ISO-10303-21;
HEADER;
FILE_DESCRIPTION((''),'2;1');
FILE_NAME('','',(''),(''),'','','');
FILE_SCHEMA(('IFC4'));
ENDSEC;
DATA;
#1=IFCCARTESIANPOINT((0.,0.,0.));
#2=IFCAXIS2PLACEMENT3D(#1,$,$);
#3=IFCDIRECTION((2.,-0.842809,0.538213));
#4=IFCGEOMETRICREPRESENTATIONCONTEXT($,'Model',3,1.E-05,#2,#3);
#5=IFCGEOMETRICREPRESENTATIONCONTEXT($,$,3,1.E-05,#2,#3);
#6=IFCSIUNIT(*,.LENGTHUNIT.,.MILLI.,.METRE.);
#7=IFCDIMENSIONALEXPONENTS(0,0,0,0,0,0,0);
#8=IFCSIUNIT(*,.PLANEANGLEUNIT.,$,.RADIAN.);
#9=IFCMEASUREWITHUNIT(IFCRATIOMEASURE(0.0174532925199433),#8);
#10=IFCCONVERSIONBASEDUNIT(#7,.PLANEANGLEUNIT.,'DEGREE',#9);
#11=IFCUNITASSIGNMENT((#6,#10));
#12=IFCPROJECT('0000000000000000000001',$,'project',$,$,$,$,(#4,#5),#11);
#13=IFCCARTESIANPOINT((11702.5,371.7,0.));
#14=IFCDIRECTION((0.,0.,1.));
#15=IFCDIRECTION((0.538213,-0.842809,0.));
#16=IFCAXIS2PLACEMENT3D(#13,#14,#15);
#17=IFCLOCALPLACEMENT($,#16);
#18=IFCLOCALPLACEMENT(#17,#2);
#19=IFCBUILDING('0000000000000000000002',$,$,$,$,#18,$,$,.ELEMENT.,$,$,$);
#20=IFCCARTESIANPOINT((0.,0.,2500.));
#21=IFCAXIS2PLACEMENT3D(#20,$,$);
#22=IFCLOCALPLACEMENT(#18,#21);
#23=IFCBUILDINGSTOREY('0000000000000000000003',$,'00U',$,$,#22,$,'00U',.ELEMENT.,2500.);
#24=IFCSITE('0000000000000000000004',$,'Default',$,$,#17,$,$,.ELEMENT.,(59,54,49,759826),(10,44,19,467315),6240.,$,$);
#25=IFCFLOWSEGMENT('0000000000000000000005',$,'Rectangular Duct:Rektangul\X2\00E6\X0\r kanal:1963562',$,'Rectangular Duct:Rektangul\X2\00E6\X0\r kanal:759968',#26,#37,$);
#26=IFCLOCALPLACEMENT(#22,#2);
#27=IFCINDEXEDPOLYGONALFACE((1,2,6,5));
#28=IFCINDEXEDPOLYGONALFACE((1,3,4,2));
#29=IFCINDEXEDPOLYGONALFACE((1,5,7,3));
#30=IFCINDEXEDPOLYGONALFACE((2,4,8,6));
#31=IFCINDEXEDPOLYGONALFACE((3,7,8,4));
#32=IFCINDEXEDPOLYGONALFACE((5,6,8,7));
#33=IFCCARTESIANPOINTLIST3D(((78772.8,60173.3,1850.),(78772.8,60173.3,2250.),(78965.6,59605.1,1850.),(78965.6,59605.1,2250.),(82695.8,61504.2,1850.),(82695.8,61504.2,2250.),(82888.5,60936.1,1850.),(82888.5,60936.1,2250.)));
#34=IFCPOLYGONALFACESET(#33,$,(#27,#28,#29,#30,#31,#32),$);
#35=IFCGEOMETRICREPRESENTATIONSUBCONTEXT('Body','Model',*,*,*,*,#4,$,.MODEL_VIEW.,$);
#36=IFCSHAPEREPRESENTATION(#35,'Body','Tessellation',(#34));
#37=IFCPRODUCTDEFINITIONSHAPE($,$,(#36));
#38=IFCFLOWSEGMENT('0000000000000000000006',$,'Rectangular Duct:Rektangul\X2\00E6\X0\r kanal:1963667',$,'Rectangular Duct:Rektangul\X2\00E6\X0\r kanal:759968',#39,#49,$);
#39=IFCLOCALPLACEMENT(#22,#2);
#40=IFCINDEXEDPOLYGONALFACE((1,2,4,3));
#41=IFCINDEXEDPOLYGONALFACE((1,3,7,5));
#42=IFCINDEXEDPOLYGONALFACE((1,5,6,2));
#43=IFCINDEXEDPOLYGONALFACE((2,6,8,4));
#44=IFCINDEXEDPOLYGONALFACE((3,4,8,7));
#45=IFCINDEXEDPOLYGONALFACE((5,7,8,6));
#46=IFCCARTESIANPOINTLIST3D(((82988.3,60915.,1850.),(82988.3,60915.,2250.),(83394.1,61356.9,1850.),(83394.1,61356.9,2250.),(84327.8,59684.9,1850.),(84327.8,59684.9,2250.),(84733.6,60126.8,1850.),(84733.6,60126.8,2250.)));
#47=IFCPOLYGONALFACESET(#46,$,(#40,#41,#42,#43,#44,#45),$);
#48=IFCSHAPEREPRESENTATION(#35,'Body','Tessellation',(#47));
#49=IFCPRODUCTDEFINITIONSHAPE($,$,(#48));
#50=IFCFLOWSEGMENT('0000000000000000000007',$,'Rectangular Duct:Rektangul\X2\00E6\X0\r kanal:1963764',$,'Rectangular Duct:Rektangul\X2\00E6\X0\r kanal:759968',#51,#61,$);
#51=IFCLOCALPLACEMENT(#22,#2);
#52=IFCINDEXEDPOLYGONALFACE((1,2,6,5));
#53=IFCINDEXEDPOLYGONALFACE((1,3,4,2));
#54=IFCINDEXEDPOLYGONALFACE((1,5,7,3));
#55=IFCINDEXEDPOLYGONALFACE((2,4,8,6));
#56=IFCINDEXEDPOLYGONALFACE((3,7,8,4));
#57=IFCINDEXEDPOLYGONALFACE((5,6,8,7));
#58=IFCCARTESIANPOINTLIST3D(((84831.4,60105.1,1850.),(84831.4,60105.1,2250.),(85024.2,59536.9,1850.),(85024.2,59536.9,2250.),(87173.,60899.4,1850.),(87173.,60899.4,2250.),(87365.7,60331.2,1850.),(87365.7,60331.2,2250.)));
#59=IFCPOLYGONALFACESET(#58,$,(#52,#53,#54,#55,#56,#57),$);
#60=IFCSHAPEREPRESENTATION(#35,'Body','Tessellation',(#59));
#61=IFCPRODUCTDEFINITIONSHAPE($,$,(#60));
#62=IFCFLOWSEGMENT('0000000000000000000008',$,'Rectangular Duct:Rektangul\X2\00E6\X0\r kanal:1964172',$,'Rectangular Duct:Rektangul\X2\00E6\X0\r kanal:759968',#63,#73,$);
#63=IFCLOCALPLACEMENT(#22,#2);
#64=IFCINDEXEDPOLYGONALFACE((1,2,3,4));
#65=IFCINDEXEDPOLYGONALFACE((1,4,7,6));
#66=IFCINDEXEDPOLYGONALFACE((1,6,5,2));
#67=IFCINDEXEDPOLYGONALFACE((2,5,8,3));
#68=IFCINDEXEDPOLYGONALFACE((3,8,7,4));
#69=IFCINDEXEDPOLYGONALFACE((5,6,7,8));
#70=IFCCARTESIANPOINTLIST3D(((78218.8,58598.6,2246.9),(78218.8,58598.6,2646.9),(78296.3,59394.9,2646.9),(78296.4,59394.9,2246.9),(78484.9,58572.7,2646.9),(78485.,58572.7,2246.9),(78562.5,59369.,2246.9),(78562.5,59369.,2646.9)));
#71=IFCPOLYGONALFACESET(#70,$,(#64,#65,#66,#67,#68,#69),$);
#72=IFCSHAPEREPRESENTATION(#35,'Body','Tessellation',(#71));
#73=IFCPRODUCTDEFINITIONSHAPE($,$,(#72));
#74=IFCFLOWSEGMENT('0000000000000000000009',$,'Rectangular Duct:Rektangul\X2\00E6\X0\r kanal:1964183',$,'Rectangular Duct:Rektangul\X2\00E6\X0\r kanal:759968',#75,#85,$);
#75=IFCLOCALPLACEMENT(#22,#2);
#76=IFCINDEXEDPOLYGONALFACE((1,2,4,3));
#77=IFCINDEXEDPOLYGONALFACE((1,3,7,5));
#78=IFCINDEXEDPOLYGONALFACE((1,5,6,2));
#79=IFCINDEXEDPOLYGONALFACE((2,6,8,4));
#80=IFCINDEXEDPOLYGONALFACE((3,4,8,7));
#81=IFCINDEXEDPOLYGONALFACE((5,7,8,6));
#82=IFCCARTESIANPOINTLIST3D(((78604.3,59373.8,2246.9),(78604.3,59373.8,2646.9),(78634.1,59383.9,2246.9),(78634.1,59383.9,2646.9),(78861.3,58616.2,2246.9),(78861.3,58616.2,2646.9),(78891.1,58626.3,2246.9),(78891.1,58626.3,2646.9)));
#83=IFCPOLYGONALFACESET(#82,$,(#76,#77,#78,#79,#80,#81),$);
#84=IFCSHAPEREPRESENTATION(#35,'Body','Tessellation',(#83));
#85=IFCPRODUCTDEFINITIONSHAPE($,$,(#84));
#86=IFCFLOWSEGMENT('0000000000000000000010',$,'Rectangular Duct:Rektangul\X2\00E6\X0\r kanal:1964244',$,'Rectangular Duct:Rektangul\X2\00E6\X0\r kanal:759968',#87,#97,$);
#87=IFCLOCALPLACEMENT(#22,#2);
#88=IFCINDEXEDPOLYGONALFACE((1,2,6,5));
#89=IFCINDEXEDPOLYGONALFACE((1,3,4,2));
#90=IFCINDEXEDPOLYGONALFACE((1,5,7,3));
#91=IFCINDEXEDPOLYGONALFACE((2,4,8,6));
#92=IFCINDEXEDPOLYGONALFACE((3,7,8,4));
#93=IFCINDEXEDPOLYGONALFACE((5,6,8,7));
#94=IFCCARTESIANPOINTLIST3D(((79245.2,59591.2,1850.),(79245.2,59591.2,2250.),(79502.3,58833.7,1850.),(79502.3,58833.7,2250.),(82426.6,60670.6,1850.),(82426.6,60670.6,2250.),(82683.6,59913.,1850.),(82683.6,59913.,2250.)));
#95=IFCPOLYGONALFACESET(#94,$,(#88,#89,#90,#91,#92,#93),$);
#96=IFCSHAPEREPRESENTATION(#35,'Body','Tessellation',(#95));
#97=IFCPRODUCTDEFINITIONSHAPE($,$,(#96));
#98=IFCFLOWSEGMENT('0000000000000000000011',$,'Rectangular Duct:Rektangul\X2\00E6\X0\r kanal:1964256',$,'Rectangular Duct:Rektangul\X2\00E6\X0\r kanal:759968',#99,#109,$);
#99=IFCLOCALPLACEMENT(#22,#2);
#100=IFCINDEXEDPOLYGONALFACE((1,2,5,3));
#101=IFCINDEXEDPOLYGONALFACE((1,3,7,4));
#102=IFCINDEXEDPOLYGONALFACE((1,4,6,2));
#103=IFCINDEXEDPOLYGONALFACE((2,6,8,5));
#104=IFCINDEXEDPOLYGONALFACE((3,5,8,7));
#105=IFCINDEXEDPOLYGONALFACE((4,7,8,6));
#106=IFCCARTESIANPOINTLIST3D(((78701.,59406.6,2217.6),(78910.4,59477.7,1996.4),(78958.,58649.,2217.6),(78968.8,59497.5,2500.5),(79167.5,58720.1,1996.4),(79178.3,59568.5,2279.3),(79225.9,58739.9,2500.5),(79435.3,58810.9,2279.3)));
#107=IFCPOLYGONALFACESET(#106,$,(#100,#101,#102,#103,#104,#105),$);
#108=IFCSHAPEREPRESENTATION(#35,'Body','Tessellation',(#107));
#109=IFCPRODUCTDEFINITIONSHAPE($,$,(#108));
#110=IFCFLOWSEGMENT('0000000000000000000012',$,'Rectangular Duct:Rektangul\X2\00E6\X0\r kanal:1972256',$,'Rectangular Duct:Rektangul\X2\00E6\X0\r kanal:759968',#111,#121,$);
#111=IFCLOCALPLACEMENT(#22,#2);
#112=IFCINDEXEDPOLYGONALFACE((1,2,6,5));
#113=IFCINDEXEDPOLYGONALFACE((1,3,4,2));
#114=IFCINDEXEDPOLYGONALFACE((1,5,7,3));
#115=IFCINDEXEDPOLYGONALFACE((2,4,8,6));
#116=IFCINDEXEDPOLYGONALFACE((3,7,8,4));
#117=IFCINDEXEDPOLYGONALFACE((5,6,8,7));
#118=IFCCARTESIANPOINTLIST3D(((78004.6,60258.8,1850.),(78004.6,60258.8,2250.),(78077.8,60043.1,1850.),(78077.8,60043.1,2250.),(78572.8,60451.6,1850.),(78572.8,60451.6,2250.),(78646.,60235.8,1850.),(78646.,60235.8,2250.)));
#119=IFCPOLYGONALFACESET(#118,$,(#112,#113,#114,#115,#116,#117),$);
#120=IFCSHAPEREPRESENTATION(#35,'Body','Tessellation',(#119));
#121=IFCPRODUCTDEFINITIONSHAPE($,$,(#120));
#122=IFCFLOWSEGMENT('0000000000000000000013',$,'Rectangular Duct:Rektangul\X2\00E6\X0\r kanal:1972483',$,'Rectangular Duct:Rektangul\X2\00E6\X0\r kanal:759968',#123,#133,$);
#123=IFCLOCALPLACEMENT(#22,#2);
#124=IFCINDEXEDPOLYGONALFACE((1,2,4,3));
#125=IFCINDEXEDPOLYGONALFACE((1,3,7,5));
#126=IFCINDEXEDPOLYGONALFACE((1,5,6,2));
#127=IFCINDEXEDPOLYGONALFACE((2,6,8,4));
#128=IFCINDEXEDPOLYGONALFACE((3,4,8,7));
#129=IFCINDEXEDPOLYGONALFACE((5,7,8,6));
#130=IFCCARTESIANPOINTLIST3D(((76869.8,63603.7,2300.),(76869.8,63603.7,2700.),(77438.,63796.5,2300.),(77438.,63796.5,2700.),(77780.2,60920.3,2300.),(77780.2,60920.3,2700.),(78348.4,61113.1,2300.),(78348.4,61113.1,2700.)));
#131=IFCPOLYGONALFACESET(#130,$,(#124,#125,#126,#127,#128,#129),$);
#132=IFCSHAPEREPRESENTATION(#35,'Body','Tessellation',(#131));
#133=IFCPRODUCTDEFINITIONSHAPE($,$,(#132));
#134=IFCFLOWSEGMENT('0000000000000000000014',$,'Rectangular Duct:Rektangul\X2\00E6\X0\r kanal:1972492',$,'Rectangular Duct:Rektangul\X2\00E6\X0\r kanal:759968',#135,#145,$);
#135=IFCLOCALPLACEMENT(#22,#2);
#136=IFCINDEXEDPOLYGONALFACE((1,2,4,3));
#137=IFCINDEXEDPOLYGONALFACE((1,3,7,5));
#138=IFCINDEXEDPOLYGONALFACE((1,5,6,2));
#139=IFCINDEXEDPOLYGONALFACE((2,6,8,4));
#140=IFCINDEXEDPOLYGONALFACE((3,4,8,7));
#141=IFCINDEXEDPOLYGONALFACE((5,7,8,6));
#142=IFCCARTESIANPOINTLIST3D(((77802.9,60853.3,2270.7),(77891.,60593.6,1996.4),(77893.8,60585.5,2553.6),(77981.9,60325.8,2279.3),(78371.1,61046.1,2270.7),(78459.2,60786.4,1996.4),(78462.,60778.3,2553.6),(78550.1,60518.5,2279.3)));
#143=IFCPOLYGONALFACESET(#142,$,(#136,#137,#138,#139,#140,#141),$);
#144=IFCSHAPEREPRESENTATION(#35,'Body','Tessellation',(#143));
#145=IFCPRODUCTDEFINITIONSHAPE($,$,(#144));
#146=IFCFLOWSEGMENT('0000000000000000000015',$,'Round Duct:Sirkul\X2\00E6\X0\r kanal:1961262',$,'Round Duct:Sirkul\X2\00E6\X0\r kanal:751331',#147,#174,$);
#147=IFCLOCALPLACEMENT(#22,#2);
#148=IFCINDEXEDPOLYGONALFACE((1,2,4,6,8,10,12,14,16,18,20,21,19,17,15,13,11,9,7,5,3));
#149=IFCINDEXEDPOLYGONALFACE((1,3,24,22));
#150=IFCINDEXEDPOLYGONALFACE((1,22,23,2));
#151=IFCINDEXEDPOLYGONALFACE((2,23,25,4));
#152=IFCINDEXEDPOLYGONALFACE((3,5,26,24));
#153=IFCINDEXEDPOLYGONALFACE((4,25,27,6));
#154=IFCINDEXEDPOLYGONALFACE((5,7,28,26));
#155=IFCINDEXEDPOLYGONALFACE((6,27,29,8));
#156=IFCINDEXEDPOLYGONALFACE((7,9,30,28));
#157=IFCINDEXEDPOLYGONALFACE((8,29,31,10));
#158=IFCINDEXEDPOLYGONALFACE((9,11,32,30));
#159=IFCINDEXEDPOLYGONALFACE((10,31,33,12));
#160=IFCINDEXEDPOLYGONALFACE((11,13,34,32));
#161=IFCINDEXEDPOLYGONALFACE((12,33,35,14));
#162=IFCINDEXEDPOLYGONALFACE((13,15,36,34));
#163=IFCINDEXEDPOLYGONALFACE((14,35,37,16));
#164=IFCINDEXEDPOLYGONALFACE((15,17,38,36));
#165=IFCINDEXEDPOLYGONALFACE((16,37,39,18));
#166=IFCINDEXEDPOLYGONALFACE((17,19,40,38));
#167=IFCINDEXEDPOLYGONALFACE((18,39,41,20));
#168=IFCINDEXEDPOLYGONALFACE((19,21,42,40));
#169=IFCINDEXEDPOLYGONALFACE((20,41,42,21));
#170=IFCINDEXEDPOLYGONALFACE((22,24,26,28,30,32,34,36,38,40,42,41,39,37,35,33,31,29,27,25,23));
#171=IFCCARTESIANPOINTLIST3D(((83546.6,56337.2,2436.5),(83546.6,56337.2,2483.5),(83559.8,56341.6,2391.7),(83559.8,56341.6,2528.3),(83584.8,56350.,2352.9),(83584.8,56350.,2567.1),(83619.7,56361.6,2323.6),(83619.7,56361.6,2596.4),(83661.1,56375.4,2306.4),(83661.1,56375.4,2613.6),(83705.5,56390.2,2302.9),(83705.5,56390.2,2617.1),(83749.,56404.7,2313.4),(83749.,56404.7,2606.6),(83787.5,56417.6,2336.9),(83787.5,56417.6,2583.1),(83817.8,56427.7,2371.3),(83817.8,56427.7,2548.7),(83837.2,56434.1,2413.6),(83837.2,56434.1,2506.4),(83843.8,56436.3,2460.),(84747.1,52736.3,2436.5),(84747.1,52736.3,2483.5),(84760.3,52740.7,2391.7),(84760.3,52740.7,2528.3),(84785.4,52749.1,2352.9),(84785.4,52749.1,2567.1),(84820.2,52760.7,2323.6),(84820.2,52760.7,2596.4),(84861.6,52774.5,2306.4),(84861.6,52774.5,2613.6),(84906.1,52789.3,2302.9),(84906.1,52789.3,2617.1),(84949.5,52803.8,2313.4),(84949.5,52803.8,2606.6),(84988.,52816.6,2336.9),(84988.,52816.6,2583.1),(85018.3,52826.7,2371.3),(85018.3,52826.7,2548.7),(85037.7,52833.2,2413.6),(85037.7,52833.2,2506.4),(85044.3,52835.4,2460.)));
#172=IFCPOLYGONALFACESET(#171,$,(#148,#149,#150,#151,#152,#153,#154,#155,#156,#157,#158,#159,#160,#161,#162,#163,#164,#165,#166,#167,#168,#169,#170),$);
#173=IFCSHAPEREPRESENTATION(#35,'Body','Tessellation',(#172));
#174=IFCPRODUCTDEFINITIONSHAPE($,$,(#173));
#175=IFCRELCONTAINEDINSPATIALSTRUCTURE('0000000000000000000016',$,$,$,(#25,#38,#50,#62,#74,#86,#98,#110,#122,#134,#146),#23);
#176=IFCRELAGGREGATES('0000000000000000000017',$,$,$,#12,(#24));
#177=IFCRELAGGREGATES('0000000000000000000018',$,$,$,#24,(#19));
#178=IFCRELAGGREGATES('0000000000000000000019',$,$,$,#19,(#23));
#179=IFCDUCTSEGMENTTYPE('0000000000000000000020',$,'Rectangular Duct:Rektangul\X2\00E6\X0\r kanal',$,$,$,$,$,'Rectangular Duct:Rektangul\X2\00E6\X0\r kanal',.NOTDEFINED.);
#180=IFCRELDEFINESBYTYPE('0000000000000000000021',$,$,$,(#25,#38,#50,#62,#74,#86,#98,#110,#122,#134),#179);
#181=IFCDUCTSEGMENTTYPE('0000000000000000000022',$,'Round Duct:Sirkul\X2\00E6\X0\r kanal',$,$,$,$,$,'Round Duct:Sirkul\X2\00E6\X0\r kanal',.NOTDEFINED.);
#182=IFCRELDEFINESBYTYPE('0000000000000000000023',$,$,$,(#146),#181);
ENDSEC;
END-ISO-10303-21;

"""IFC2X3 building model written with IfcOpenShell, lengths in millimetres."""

from ifc_helpers import new_model, entity, si_unit, converted_unit, direction, frame, frame_2d, origin, origin_2d_with_axis, place, context, subcontext, project, spatial, rectangle, circle, extrude, type_object, element, save


model = new_model("IFC2X3")

# Units and contexts
model_context = context("Model", 3, precision=1e-05, world=origin(), true_north=direction((2.0, -0.842809, 0.538213)))
context_of_model = context(None, 3, precision=1e-05, world=origin(), true_north=direction((2.0, -0.842809, 0.538213)))
body_context = subcontext(model_context, "Body", "Model", "MODEL_VIEW")
ifc_project = project(units=[si_unit("LENGTHUNIT", "METRE", prefix="MILLI"), converted_unit("PLANEANGLEUNIT", "DEGREE", entity("IfcRatioMeasure", 0.0174532925199433), si_unit("PLANEANGLEUNIT", "RADIAN"), dimensions=[0, 0, 0, 0, 0, 0, 0])], contexts=[model_context, context_of_model])

# Site, building, storey
site_placement = place(None, frame((11702.5, 371.7, 0.0), z_axis=(0.0, 0.0, 1.0), x_axis=(0.538213, -0.842809, 0.0)))
site = spatial("IfcSite", under=ifc_project, at=site_placement, Name="Default", CompositionType="ELEMENT", RefLatitude=(59, 54, 49, 759826), RefLongitude=(10, 44, 19, 467315), RefElevation=6240.0)
building_placement = place(site_placement, origin())
building = spatial("IfcBuilding", under=site, at=building_placement, CompositionType="ELEMENT")
storey_placement = place(building_placement, frame((0.0, 0.0, 2500.0)))
storey = spatial("IfcBuildingStorey", under=building, at=storey_placement, Name="00U", LongName="00U", CompositionType="ELEMENT", Elevation=2500.0)

# Flow segments
duct_segment_type_1 = type_object("IfcDuctSegmentType", Name="Rectangular Duct:Rektangulær kanal", ElementType="Rectangular Duct:Rektangulær kanal", PredefinedType="NOTDEFINED")
flow_segment_1_placement = place(storey_placement, origin())
element("IfcFlowSegment", 1, at=flow_segment_1_placement, inside=storey, type_object=duct_segment_type_1, Name="Rectangular Duct:Rektangulær kanal:1963562", ObjectType="Rectangular Duct:Rektangulær kanal:759968", context=body_context, shape_type="SweptSolid", body=[
    extrude(rectangle(XDim=4142.6, YDim=600.0, at=frame_2d((0.0, 0.0), x_axis=(1.0, 0.0))), frame((80830.7, 60554.7, 1850.0), z_axis=(0.0, 0.0, 1.0), x_axis=(0.94698, 0.321291, 0.0)), (0.0, 0.0, 1.0), 400.0),
])
flow_segment_2_placement = place(storey_placement, origin())
element("IfcFlowSegment", 2, at=flow_segment_2_placement, inside=storey, type_object=duct_segment_type_1, Name="Rectangular Duct:Rektangulær kanal:1963667", ObjectType="Rectangular Duct:Rektangulær kanal:759968", context=body_context, shape_type="SweptSolid", body=[
    extrude(rectangle(XDim=1818.6, YDim=600.0, at=frame_2d((0.0, 0.0), x_axis=(1.0, 0.0))), frame((83861.0, 60520.9, 1850.0), z_axis=(0.0, 0.0, 1.0), x_axis=(0.736545, -0.676389, 0.0)), (0.0, 0.0, 1.0), 400.0),
])
flow_segment_3_placement = place(storey_placement, origin())
element("IfcFlowSegment", 3, at=flow_segment_3_placement, inside=storey, type_object=duct_segment_type_1, Name="Rectangular Duct:Rektangulær kanal:1963764", ObjectType="Rectangular Duct:Rektangulær kanal:759968", context=body_context, shape_type="SweptSolid", body=[
    extrude(rectangle(XDim=2472.6, YDim=600.0, at=frame_2d((0.0, 0.0), x_axis=(1.0, 0.0))), frame((86098.6, 60218.2, 1850.0), z_axis=(0.0, 0.0, 1.0), x_axis=(0.946996, 0.321246, 0.0)), (0.0, 0.0, 1.0), 400.0),
])
flow_segment_4_placement = place(storey_placement, origin())
element("IfcFlowSegment", 4, at=flow_segment_4_placement, inside=storey, type_object=duct_segment_type_1, Name="Rectangular Duct:Rektangulær kanal:1964172", ObjectType="Rectangular Duct:Rektangulær kanal:759968", context=body_context, shape_type="SweptSolid", body=[
    extrude(rectangle(XDim=400.0, YDim=267.4, at=frame_2d((0.0, 0.0), x_axis=(0.0, 1.0))), frame((78351.9, 58585.7, 2446.9), z_axis=(0.096924, 0.995292, 0.0), x_axis=(0.995292, -0.096924, 0.000084)), (0.0, 0.0, 1.0), 800.0),
])
flow_segment_5_placement = place(storey_placement, origin())
element("IfcFlowSegment", 5, at=flow_segment_5_placement, inside=storey, type_object=duct_segment_type_1, Name="Rectangular Duct:Rektangulær kanal:1964183", ObjectType="Rectangular Duct:Rektangulær kanal:759968", context=body_context, shape_type="SweptSolid", body=[
    extrude(rectangle(XDim=31.4, YDim=800.0, at=frame_2d((0.0, 0.0), x_axis=(1.0, 0.0))), frame((78747.7, 59000.0, 2246.9), z_axis=(0.0, 0.0, 1.0), x_axis=(0.946994, 0.321251, 0.0)), (0.0, 0.0, 1.0), 400.0),
])
flow_segment_6_placement = place(storey_placement, origin())
element("IfcFlowSegment", 6, at=flow_segment_6_placement, inside=storey, type_object=duct_segment_type_1, Name="Rectangular Duct:Rektangulær kanal:1964244", ObjectType="Rectangular Duct:Rektangulær kanal:759968", context=body_context, shape_type="SweptSolid", body=[
    extrude(rectangle(XDim=3359.4, YDim=800.0, at=frame_2d((0.0, 0.0), x_axis=(1.0, 0.0))), frame((80964.4, 59752.1, 1850.0), z_axis=(0.0, 0.0, 1.0), x_axis=(0.94698, 0.321291, 0.0)), (0.0, 0.0, 1.0), 400.0),
])
flow_segment_7_placement = place(storey_placement, origin())
element("IfcFlowSegment", 7, at=flow_segment_7_placement, inside=storey, type_object=duct_segment_type_1, Name="Rectangular Duct:Rektangulær kanal:1964256", ObjectType="Rectangular Duct:Rektangulær kanal:759968", context=body_context, shape_type="SweptSolid", body=[
    extrude(rectangle(XDim=312.8, YDim=400.0, at=frame_2d((0.0, 0.0), x_axis=(1.0, 0.0))), frame((79196.7, 58730.0, 2248.5), z_axis=(-0.321291, 0.94698, 0.0), x_axis=(0.669616, 0.227187, -0.707107)), (0.0, 0.0, 1.0), 800.0),
])
flow_segment_8_placement = place(storey_placement, origin())
element("IfcFlowSegment", 8, at=flow_segment_8_placement, inside=storey, type_object=duct_segment_type_1, Name="Rectangular Duct:Rektangulær kanal:1972256", ObjectType="Rectangular Duct:Rektangulær kanal:759968", context=body_context, shape_type="SweptSolid", body=[
    extrude(rectangle(XDim=227.8, YDim=600.0, at=frame_2d((0.0, 0.0), x_axis=(1.0, 0.0))), frame((78325.3, 60247.3, 1850.0), z_axis=(0.0, 0.0, 1.0), x_axis=(-0.321291, 0.94698, 0.0)), (0.0, 0.0, 1.0), 400.0),
])
flow_segment_9_placement = place(storey_placement, origin())
element("IfcFlowSegment", 9, at=flow_segment_9_placement, inside=storey, type_object=duct_segment_type_1, Name="Rectangular Duct:Rektangulær kanal:1972483", ObjectType="Rectangular Duct:Rektangulær kanal:759968", context=body_context, shape_type="SweptSolid", body=[
    extrude(rectangle(XDim=2833.7, YDim=600.0, at=frame_2d((0.0, 0.0), x_axis=(1.0, 0.0))), frame((77609.1, 62358.4, 2300.0), z_axis=(0.0, 0.0, 1.0), x_axis=(-0.321291, 0.94698, 0.0)), (0.0, 0.0, 1.0), 400.0),
])
flow_segment_10_placement = place(storey_placement, origin())
element("IfcFlowSegment", 10, at=flow_segment_10_placement, inside=storey, type_object=duct_segment_type_1, Name="Rectangular Duct:Rektangulær kanal:1972492", ObjectType="Rectangular Duct:Rektangulær kanal:759968", context=body_context, shape_type="SweptSolid", body=[
    extrude(rectangle(XDim=400.0, YDim=387.9, at=frame_2d((0.0, 0.0), x_axis=(0.0, 1.0))), frame((77892.4, 60589.5, 2275.0), z_axis=(0.94698, 0.321291, 0.0), x_axis=(-0.227187, 0.669616, 0.707107)), (0.0, 0.0, 1.0), 600.0),
])
duct_segment_type_2 = type_object("IfcDuctSegmentType", Name="Round Duct:Sirkulær kanal", ElementType="Round Duct:Sirkulær kanal", PredefinedType="NOTDEFINED")
flow_segment_11_placement = place(storey_placement, origin())
element("IfcFlowSegment", 11, at=flow_segment_11_placement, inside=storey, type_object=duct_segment_type_2, Name="Round Duct:Sirkulær kanal:1961262", ObjectType="Round Duct:Sirkulær kanal:751331", context=body_context, shape_type="SweptSolid", body=[
    extrude(circle(Radius=157.5, at=origin_2d_with_axis()), frame((83694.4, 56386.5, 2460.0), z_axis=(0.316277, -0.948667, 0.0), x_axis=(0.948667, 0.316277, 0.0)), (0.0, 0.0, 1.0), 3795.8),
])

save(model, "model.ifc")
